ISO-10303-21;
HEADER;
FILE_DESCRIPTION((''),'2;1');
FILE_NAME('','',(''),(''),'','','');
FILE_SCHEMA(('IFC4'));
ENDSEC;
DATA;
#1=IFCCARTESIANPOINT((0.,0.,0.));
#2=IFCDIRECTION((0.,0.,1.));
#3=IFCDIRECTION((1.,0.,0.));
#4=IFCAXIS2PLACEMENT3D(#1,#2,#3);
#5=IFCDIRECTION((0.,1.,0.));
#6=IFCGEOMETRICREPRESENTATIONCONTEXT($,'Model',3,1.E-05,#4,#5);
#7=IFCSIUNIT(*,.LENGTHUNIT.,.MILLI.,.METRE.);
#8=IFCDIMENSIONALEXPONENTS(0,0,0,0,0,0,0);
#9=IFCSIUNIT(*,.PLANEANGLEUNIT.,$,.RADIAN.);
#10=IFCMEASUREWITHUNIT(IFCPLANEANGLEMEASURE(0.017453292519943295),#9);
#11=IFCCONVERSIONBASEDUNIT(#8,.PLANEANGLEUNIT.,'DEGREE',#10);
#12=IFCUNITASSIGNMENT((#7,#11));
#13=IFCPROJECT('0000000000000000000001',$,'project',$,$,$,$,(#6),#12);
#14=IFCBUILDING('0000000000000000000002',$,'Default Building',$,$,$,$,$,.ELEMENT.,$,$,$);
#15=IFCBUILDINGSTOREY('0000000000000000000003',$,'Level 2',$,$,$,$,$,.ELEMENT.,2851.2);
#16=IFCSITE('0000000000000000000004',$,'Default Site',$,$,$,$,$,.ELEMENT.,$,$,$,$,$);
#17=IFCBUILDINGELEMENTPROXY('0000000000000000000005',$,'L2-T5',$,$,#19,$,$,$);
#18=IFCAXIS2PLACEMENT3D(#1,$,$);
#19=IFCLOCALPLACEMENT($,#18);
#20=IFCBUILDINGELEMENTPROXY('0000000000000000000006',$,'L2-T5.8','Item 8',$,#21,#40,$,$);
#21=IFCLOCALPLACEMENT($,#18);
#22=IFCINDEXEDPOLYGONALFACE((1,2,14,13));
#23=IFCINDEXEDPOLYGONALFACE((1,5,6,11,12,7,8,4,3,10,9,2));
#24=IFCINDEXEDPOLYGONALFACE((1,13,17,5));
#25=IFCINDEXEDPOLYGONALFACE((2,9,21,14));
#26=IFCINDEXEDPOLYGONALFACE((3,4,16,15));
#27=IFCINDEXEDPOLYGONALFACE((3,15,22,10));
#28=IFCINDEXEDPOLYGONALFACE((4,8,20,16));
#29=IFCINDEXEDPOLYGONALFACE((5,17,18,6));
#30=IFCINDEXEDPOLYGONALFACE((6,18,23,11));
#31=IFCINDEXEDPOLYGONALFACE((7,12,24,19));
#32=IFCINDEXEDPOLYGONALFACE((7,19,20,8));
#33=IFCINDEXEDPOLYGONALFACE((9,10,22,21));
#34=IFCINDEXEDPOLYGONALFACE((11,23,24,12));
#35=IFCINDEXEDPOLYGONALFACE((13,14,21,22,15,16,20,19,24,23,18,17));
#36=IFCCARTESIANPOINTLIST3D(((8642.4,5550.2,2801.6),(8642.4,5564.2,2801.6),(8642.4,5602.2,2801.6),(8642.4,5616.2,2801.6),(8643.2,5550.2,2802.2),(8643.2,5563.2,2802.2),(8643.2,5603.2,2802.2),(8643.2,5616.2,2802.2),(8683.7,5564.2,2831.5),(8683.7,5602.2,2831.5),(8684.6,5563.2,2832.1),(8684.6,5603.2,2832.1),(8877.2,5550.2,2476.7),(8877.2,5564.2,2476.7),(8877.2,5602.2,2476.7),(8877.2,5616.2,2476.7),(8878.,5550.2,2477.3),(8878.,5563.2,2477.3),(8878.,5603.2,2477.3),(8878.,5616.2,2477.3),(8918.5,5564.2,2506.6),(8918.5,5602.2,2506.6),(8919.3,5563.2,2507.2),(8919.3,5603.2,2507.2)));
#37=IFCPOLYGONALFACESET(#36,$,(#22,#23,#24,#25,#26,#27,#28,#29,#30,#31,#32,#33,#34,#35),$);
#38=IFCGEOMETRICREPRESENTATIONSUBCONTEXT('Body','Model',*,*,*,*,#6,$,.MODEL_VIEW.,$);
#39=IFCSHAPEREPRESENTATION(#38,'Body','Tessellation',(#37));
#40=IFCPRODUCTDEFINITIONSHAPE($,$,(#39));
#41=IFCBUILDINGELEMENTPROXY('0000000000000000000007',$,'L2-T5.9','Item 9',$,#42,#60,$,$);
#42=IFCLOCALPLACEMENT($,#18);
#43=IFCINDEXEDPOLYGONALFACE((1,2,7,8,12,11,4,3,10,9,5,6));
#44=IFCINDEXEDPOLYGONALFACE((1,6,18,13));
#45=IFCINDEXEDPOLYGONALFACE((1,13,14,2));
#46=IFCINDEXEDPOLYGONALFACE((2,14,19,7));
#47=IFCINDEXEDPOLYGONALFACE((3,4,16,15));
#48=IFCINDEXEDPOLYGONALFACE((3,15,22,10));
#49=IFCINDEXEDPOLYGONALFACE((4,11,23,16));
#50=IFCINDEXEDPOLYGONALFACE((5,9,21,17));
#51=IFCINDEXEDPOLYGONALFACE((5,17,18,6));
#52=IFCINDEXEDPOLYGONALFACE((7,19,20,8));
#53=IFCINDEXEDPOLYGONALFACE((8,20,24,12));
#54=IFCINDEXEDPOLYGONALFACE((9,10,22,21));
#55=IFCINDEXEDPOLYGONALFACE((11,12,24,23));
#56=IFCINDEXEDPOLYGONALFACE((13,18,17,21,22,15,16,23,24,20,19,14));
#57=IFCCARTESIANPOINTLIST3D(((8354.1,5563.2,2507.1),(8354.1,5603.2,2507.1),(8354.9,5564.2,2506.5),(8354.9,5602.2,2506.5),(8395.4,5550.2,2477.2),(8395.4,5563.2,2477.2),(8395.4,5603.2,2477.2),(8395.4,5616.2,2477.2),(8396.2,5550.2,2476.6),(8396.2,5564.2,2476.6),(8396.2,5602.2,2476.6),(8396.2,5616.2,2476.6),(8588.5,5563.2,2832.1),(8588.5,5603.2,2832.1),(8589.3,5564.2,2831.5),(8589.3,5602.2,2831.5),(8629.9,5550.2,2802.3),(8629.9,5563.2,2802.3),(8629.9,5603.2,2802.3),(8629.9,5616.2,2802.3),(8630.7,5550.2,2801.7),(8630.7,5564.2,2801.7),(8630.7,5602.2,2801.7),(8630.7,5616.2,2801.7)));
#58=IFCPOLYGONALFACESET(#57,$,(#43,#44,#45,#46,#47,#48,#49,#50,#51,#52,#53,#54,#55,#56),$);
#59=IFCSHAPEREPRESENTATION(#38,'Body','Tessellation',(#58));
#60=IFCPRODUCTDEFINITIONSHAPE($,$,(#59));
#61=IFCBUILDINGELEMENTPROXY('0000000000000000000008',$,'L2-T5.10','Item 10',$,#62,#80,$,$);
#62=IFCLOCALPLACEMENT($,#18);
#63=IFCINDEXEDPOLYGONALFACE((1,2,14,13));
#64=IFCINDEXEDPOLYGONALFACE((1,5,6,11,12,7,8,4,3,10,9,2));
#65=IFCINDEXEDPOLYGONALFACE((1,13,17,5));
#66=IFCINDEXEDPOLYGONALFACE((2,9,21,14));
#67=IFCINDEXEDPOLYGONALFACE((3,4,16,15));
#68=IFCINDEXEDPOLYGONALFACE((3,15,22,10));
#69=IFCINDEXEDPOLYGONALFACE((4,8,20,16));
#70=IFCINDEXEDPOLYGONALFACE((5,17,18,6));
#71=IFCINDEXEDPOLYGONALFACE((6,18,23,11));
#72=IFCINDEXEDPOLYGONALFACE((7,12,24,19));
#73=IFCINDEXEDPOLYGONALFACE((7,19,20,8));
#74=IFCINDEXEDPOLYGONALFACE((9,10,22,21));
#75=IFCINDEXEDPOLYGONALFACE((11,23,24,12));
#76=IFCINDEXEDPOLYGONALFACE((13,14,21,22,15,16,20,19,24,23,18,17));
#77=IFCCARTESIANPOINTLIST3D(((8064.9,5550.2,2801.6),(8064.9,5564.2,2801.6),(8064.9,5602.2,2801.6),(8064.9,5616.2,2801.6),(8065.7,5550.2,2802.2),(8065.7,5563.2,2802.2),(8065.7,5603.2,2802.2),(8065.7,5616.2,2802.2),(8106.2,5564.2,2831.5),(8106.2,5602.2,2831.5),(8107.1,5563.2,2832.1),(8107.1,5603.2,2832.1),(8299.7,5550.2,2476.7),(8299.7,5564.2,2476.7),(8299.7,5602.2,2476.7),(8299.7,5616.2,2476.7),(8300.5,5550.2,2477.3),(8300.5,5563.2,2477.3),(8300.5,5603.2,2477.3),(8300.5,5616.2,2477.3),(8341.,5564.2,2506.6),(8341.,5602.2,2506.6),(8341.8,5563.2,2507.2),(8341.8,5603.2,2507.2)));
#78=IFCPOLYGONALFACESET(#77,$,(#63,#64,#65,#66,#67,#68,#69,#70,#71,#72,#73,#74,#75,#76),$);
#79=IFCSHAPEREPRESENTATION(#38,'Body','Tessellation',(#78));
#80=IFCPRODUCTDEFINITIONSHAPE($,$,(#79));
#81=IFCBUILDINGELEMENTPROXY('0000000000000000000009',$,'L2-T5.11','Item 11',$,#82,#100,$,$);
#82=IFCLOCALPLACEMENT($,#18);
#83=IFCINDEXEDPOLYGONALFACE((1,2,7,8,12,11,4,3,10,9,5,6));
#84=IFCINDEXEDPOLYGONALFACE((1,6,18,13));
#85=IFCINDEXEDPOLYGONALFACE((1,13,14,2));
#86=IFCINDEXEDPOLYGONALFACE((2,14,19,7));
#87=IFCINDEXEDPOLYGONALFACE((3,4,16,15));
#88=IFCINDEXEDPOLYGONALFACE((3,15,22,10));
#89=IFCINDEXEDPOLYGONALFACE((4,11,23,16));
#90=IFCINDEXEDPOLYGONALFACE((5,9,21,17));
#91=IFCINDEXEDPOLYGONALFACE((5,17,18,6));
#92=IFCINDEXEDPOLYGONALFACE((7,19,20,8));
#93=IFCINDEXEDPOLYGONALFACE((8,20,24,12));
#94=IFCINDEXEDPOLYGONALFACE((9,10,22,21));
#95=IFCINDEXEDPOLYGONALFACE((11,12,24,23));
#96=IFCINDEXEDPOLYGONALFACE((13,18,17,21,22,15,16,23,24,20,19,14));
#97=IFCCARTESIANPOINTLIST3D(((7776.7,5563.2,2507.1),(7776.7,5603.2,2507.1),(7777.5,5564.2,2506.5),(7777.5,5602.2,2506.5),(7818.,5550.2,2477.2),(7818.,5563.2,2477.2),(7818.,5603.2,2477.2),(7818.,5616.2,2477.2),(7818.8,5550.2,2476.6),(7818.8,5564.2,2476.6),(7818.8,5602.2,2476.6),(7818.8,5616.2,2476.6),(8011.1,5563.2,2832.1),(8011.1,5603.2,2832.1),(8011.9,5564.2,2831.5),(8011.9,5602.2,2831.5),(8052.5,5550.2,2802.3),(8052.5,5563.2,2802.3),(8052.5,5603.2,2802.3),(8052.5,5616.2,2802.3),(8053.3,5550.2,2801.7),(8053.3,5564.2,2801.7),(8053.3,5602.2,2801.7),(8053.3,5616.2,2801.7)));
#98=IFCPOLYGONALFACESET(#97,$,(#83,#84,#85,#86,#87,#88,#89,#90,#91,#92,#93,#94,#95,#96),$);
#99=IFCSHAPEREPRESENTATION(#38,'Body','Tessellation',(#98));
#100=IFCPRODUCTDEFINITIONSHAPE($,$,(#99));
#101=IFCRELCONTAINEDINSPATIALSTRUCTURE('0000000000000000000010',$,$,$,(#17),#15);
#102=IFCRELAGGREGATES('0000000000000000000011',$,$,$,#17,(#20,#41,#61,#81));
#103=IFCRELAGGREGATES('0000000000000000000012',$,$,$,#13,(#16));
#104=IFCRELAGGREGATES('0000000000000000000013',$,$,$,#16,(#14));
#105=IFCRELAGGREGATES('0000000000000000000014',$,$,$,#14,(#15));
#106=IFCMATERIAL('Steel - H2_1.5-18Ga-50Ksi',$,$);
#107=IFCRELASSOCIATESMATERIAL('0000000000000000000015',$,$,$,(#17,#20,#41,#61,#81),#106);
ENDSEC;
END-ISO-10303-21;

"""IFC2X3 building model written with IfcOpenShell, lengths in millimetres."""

from ifc_helpers import new_model, entity, si_unit, converted_unit, direction, frame, origin, origin_with_axes, place, context, subcontext, project, spatial, polyline, outline, extrude, material, element, aggregate, save


model = new_model("IFC2X3")

# Units and contexts
model_context = context("Model", 3, precision=1e-05, world=origin_with_axes(), true_north=direction((0.0, 1.0, 0.0)))
body_context = subcontext(model_context, "Body", "Model", "MODEL_VIEW")
ifc_project = project(units=[si_unit("LENGTHUNIT", "METRE", prefix="MILLI"), converted_unit("PLANEANGLEUNIT", "DEGREE", entity("IfcPlaneAngleMeasure", 0.017453292519943295), si_unit("PLANEANGLEUNIT", "RADIAN"), dimensions=[0, 0, 0, 0, 0, 0, 0])], contexts=[model_context])

# Site, building, storey
site = spatial("IfcSite", under=ifc_project, Name="Default Site", CompositionType="ELEMENT")
building = spatial("IfcBuilding", under=site, Name="Default Building", CompositionType="ELEMENT")
storey = spatial("IfcBuildingStorey", under=building, Name="Level 2", CompositionType="ELEMENT", Elevation=2851.2)

# Building element proxies
ifc_material_1 = material(Name="Steel - H2_1.5-18Ga-50Ksi")
proxy_1 = element("IfcBuildingElementProxy", 1, inside=storey, material=ifc_material_1, Name="L2-T5")
proxy_2_placement = place(None, frame((8877.2, 5616.2, 2476.7), z_axis=(-0.586, 0.0, 0.811), x_axis=(0.0, -40.0, 0.0)))
proxy_2 = element("IfcBuildingElementProxy", 2, at=proxy_2_placement, material=ifc_material_1, Name="L2-T5.8", Description="Item 8", context=body_context, shape_type="SweptSolid", body=[
    extrude(outline(polyline([(0.0, 0.0), (14.0, 0.0), (14.0, 51.0), (52.0, 51.0), (52.0, 0.0), (66.0, 0.0), (66.0, 1.0), (53.0, 1.0), (53.0, 52.0), (13.0, 52.0), (13.0, 1.0), (0.0, 1.0), (0.0, 0.0)])), origin(), (0.0, 0.0, 1.0), 400.9),
])
proxy_3_placement = place(None, frame((8630.7, 5616.2, 2801.7), z_axis=(-0.585, 0.0, -0.811), x_axis=(0.0, -40.0, 0.0)))
proxy_3 = element("IfcBuildingElementProxy", 3, at=proxy_3_placement, material=ifc_material_1, Name="L2-T5.9", Description="Item 9", context=body_context, shape_type="SweptSolid", body=[
    extrude(outline(polyline([(0.0, 0.0), (14.0, 0.0), (14.0, 51.0), (52.0, 51.0), (52.0, 0.0), (66.0, 0.0), (66.0, 1.0), (53.0, 1.0), (53.0, 52.0), (13.0, 52.0), (13.0, 1.0), (0.0, 1.0), (0.0, 0.0)])), origin(), (0.0, 0.0, 1.0), 400.8),
])
proxy_4_placement = place(None, frame((8299.7, 5616.2, 2476.7), z_axis=(-0.586, 0.0, 0.811), x_axis=(0.0, -40.0, 0.0)))
proxy_4 = element("IfcBuildingElementProxy", 4, at=proxy_4_placement, material=ifc_material_1, Name="L2-T5.10", Description="Item 10", context=body_context, shape_type="SweptSolid", body=[
    extrude(outline(polyline([(0.0, 0.0), (14.0, 0.0), (14.0, 51.0), (52.0, 51.0), (52.0, 0.0), (66.0, 0.0), (66.0, 1.0), (53.0, 1.0), (53.0, 52.0), (13.0, 52.0), (13.0, 1.0), (0.0, 1.0), (0.0, 0.0)])), origin(), (0.0, 0.0, 1.0), 400.9),
])
proxy_5_placement = place(None, frame((8053.3, 5616.2, 2801.7), z_axis=(-0.585, 0.0, -0.811), x_axis=(0.0, -40.0, 0.0)))
proxy_5 = element("IfcBuildingElementProxy", 5, at=proxy_5_placement, material=ifc_material_1, Name="L2-T5.11", Description="Item 11", context=body_context, shape_type="SweptSolid", body=[
    extrude(outline(polyline([(0.0, 0.0), (14.0, 0.0), (14.0, 51.0), (52.0, 51.0), (52.0, 0.0), (66.0, 0.0), (66.0, 1.0), (53.0, 1.0), (53.0, 52.0), (13.0, 52.0), (13.0, 1.0), (0.0, 1.0), (0.0, 0.0)])), origin(), (0.0, 0.0, 1.0), 400.8),
])
aggregate(proxy_1, [proxy_2, proxy_3, proxy_4, proxy_5])

save(model, "model.ifc")
